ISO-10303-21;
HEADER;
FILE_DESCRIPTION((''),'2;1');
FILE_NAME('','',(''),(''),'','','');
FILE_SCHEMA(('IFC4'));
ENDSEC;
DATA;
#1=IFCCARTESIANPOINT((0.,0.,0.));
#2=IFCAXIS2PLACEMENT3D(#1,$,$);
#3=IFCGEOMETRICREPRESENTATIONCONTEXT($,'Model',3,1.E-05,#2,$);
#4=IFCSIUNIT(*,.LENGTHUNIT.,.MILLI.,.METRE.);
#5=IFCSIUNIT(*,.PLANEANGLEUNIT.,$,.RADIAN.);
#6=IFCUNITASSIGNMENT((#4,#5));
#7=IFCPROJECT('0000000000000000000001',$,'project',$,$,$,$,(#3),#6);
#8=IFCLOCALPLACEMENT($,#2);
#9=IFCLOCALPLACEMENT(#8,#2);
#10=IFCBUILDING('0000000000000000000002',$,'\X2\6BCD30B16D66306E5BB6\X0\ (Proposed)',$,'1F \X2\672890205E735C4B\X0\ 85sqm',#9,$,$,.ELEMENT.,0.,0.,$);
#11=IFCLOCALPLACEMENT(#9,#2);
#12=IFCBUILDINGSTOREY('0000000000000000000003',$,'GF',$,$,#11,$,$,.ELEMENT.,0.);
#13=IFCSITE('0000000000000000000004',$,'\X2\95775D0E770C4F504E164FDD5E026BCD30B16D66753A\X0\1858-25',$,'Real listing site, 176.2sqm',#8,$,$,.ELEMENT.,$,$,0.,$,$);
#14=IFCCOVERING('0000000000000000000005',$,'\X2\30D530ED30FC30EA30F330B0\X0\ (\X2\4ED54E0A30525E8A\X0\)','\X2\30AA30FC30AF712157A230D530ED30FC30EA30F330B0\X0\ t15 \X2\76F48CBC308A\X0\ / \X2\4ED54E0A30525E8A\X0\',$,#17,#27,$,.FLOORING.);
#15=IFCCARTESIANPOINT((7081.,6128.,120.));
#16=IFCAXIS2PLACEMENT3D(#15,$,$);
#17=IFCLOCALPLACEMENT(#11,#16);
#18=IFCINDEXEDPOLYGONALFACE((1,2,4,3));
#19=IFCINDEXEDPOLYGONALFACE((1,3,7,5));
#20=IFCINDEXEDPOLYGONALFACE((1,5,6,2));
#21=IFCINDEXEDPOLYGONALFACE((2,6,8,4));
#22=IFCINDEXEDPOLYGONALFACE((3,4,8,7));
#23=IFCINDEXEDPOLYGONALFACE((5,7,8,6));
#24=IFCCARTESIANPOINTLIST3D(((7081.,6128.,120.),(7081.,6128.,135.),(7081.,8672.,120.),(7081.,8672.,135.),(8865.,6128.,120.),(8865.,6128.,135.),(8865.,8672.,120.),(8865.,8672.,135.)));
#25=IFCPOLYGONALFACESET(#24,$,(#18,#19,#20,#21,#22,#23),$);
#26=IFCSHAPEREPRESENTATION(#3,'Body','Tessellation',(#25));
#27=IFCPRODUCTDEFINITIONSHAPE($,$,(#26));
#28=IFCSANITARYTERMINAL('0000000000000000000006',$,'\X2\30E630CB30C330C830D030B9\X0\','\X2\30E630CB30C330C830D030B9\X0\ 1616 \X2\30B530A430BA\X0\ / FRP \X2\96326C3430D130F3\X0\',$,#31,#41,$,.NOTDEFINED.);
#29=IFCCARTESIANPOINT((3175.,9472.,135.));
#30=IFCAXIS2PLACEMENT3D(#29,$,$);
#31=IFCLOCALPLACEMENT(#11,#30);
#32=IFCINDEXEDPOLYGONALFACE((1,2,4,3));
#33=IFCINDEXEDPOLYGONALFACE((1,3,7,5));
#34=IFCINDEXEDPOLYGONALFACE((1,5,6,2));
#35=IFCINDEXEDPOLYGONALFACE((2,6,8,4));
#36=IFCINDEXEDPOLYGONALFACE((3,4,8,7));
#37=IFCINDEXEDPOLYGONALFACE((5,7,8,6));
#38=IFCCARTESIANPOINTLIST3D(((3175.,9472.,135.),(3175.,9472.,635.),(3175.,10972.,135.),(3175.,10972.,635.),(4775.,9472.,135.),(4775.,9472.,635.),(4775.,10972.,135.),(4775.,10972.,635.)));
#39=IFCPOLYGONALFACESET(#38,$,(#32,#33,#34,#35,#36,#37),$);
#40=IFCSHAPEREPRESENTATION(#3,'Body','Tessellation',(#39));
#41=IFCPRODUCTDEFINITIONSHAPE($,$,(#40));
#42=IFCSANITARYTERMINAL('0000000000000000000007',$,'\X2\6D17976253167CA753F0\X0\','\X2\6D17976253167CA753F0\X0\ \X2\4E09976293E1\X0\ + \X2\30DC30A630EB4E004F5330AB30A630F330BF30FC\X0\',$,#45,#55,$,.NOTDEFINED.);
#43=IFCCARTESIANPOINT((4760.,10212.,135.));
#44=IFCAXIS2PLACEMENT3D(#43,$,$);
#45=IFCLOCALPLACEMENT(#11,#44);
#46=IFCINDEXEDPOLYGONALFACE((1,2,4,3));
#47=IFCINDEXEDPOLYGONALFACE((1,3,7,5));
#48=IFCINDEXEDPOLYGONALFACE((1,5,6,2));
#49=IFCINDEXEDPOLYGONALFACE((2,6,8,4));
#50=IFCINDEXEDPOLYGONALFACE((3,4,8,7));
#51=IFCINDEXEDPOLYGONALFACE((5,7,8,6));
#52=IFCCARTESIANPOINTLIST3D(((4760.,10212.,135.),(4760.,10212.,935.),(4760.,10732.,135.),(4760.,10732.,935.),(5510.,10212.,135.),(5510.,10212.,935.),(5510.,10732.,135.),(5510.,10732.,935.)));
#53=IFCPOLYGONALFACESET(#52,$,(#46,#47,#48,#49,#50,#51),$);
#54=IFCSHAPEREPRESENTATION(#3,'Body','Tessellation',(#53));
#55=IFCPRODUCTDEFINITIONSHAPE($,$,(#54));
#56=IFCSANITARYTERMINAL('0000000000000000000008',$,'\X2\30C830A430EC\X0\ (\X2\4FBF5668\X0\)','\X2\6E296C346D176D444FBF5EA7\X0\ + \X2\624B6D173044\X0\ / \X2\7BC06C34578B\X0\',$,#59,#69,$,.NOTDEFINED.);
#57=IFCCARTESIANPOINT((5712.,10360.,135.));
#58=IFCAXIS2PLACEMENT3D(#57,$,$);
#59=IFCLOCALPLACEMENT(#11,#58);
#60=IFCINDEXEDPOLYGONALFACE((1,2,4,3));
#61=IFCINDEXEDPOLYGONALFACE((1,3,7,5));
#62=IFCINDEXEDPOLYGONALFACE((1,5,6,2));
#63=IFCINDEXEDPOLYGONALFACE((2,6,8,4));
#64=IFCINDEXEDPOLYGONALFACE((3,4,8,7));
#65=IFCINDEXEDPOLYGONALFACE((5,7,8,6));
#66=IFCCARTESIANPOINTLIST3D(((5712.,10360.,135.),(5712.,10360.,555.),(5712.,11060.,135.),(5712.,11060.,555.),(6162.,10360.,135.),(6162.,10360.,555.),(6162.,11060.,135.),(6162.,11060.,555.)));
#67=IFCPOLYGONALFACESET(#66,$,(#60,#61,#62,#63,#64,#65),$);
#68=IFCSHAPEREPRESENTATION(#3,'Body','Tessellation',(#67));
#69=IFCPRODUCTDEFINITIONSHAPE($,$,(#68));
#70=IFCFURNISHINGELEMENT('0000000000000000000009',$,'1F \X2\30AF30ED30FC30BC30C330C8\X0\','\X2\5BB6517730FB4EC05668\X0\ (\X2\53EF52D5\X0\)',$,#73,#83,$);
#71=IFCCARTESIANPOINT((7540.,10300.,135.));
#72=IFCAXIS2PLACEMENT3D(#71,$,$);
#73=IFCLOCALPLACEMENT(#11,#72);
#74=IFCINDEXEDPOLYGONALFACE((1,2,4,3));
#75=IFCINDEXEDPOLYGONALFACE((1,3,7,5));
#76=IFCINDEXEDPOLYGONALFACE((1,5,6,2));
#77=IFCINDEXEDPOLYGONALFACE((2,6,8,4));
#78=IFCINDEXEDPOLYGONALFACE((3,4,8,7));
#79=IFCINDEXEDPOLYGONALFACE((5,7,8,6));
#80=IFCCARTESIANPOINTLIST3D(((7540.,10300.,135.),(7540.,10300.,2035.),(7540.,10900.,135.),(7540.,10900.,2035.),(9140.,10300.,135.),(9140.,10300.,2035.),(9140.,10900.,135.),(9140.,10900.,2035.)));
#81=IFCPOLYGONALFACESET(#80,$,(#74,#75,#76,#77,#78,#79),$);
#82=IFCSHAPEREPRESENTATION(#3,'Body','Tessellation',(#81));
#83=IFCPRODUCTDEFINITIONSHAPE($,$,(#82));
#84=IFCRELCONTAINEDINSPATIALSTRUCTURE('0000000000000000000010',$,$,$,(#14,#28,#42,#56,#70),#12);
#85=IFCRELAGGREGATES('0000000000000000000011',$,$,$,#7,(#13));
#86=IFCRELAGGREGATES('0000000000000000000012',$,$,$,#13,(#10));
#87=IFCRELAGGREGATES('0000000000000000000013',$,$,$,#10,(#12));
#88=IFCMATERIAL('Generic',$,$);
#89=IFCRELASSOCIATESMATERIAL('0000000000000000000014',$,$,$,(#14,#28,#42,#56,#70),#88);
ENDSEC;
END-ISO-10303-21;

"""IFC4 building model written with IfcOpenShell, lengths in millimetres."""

from ifc_helpers import new_model, si_unit, frame, frame_2d, origin, place, context, project, spatial, rectangle, extrude, material, element, save


model = new_model("IFC4")

# Units and contexts
model_context = context("Model", 3, precision=1e-05, world=origin())
ifc_project = project(units=[si_unit("LENGTHUNIT", "METRE", prefix="MILLI"), si_unit("PLANEANGLEUNIT", "RADIAN")], contexts=[model_context])

# Site, building, storey
site_placement = place(None, origin())
site = spatial("IfcSite", under=ifc_project, at=site_placement, Name="長崎県佐世保市母ケ浦町1858-25", ObjectType="Real listing site, 176.2sqm", CompositionType="ELEMENT", RefElevation=0.0)
building_placement = place(site_placement, origin())
building = spatial("IfcBuilding", under=site, at=building_placement, Name="母ケ浦の家 (Proposed)", ObjectType="1F 木造平屋 85sqm", CompositionType="ELEMENT", ElevationOfRefHeight=0.0, ElevationOfTerrain=0.0)
storey_placement = place(building_placement, origin())
storey = spatial("IfcBuildingStorey", under=building, at=storey_placement, Name="GF", CompositionType="ELEMENT", Elevation=0.0)

# Covering
ifc_material_1 = material(Name="Generic")
covering_1_placement = place(storey_placement, frame((7081.0, 6128.0, 120.0)))
element("IfcCovering", 1, at=covering_1_placement, inside=storey, material=ifc_material_1, Name="フローリング (仕上げ床)", Description="オーク無垢フローリング t15 直貼り / 仕上げ床", PredefinedType="FLOORING", context=model_context, shape_type="SweptSolid", body=[
    extrude(rectangle(XDim=1784.0, YDim=2544.0, at=frame_2d((892.0, 1272.0))), frame((7081.0, 6128.0, 120.0)), (0.0, 0.0, 1.0), 15.0),
])

# Sanitary terminals
sanitary_terminal_1_placement = place(storey_placement, frame((3175.0, 9472.0, 135.0)))
element("IfcSanitaryTerminal", 2, at=sanitary_terminal_1_placement, inside=storey, material=ifc_material_1, Name="ユニットバス", Description="ユニットバス 1616 サイズ / FRP 防水パン", PredefinedType="NOTDEFINED", context=model_context, shape_type="SweptSolid", body=[
    extrude(rectangle(XDim=1600.0, YDim=1500.0, at=frame_2d((800.0, 750.0))), frame((3175.0, 9472.0, 135.0)), (0.0, 0.0, 1.0), 500.0),
])
sanitary_terminal_2_placement = place(storey_placement, frame((4760.0, 10212.0, 135.0)))
element("IfcSanitaryTerminal", 3, at=sanitary_terminal_2_placement, inside=storey, material=ifc_material_1, Name="洗面化粧台", Description="洗面化粧台 三面鏡 + ボウル一体カウンター", PredefinedType="NOTDEFINED", context=model_context, shape_type="SweptSolid", body=[
    extrude(rectangle(XDim=750.0, YDim=520.0, at=frame_2d((375.0, 260.0))), frame((4760.0, 10212.0, 135.0)), (0.0, 0.0, 1.0), 800.0),
])
sanitary_terminal_3_placement = place(storey_placement, frame((5712.0, 10360.0, 135.0)))
element("IfcSanitaryTerminal", 4, at=sanitary_terminal_3_placement, inside=storey, material=ifc_material_1, Name="トイレ (便器)", Description="温水洗浄便座 + 手洗い / 節水型", PredefinedType="NOTDEFINED", context=model_context, shape_type="SweptSolid", body=[
    extrude(rectangle(XDim=450.0, YDim=700.0, at=frame_2d((225.0, 350.0))), frame((5712.0, 10360.0, 135.0)), (0.0, 0.0, 1.0), 420.0),
])

# Furnishing element
furnishing_placement = place(storey_placement, frame((7540.0, 10300.0, 135.0)))
element("IfcFurnishingElement", 5, at=furnishing_placement, inside=storey, material=ifc_material_1, Name="1F クローゼット", Description="家具・什器 (可動)", context=model_context, shape_type="SweptSolid", body=[
    extrude(rectangle(XDim=1600.0, YDim=600.0, at=frame_2d((800.0, 300.0))), frame((7540.0, 10300.0, 135.0)), (0.0, 0.0, 1.0), 1900.0),
])

save(model, "model.ifc")
